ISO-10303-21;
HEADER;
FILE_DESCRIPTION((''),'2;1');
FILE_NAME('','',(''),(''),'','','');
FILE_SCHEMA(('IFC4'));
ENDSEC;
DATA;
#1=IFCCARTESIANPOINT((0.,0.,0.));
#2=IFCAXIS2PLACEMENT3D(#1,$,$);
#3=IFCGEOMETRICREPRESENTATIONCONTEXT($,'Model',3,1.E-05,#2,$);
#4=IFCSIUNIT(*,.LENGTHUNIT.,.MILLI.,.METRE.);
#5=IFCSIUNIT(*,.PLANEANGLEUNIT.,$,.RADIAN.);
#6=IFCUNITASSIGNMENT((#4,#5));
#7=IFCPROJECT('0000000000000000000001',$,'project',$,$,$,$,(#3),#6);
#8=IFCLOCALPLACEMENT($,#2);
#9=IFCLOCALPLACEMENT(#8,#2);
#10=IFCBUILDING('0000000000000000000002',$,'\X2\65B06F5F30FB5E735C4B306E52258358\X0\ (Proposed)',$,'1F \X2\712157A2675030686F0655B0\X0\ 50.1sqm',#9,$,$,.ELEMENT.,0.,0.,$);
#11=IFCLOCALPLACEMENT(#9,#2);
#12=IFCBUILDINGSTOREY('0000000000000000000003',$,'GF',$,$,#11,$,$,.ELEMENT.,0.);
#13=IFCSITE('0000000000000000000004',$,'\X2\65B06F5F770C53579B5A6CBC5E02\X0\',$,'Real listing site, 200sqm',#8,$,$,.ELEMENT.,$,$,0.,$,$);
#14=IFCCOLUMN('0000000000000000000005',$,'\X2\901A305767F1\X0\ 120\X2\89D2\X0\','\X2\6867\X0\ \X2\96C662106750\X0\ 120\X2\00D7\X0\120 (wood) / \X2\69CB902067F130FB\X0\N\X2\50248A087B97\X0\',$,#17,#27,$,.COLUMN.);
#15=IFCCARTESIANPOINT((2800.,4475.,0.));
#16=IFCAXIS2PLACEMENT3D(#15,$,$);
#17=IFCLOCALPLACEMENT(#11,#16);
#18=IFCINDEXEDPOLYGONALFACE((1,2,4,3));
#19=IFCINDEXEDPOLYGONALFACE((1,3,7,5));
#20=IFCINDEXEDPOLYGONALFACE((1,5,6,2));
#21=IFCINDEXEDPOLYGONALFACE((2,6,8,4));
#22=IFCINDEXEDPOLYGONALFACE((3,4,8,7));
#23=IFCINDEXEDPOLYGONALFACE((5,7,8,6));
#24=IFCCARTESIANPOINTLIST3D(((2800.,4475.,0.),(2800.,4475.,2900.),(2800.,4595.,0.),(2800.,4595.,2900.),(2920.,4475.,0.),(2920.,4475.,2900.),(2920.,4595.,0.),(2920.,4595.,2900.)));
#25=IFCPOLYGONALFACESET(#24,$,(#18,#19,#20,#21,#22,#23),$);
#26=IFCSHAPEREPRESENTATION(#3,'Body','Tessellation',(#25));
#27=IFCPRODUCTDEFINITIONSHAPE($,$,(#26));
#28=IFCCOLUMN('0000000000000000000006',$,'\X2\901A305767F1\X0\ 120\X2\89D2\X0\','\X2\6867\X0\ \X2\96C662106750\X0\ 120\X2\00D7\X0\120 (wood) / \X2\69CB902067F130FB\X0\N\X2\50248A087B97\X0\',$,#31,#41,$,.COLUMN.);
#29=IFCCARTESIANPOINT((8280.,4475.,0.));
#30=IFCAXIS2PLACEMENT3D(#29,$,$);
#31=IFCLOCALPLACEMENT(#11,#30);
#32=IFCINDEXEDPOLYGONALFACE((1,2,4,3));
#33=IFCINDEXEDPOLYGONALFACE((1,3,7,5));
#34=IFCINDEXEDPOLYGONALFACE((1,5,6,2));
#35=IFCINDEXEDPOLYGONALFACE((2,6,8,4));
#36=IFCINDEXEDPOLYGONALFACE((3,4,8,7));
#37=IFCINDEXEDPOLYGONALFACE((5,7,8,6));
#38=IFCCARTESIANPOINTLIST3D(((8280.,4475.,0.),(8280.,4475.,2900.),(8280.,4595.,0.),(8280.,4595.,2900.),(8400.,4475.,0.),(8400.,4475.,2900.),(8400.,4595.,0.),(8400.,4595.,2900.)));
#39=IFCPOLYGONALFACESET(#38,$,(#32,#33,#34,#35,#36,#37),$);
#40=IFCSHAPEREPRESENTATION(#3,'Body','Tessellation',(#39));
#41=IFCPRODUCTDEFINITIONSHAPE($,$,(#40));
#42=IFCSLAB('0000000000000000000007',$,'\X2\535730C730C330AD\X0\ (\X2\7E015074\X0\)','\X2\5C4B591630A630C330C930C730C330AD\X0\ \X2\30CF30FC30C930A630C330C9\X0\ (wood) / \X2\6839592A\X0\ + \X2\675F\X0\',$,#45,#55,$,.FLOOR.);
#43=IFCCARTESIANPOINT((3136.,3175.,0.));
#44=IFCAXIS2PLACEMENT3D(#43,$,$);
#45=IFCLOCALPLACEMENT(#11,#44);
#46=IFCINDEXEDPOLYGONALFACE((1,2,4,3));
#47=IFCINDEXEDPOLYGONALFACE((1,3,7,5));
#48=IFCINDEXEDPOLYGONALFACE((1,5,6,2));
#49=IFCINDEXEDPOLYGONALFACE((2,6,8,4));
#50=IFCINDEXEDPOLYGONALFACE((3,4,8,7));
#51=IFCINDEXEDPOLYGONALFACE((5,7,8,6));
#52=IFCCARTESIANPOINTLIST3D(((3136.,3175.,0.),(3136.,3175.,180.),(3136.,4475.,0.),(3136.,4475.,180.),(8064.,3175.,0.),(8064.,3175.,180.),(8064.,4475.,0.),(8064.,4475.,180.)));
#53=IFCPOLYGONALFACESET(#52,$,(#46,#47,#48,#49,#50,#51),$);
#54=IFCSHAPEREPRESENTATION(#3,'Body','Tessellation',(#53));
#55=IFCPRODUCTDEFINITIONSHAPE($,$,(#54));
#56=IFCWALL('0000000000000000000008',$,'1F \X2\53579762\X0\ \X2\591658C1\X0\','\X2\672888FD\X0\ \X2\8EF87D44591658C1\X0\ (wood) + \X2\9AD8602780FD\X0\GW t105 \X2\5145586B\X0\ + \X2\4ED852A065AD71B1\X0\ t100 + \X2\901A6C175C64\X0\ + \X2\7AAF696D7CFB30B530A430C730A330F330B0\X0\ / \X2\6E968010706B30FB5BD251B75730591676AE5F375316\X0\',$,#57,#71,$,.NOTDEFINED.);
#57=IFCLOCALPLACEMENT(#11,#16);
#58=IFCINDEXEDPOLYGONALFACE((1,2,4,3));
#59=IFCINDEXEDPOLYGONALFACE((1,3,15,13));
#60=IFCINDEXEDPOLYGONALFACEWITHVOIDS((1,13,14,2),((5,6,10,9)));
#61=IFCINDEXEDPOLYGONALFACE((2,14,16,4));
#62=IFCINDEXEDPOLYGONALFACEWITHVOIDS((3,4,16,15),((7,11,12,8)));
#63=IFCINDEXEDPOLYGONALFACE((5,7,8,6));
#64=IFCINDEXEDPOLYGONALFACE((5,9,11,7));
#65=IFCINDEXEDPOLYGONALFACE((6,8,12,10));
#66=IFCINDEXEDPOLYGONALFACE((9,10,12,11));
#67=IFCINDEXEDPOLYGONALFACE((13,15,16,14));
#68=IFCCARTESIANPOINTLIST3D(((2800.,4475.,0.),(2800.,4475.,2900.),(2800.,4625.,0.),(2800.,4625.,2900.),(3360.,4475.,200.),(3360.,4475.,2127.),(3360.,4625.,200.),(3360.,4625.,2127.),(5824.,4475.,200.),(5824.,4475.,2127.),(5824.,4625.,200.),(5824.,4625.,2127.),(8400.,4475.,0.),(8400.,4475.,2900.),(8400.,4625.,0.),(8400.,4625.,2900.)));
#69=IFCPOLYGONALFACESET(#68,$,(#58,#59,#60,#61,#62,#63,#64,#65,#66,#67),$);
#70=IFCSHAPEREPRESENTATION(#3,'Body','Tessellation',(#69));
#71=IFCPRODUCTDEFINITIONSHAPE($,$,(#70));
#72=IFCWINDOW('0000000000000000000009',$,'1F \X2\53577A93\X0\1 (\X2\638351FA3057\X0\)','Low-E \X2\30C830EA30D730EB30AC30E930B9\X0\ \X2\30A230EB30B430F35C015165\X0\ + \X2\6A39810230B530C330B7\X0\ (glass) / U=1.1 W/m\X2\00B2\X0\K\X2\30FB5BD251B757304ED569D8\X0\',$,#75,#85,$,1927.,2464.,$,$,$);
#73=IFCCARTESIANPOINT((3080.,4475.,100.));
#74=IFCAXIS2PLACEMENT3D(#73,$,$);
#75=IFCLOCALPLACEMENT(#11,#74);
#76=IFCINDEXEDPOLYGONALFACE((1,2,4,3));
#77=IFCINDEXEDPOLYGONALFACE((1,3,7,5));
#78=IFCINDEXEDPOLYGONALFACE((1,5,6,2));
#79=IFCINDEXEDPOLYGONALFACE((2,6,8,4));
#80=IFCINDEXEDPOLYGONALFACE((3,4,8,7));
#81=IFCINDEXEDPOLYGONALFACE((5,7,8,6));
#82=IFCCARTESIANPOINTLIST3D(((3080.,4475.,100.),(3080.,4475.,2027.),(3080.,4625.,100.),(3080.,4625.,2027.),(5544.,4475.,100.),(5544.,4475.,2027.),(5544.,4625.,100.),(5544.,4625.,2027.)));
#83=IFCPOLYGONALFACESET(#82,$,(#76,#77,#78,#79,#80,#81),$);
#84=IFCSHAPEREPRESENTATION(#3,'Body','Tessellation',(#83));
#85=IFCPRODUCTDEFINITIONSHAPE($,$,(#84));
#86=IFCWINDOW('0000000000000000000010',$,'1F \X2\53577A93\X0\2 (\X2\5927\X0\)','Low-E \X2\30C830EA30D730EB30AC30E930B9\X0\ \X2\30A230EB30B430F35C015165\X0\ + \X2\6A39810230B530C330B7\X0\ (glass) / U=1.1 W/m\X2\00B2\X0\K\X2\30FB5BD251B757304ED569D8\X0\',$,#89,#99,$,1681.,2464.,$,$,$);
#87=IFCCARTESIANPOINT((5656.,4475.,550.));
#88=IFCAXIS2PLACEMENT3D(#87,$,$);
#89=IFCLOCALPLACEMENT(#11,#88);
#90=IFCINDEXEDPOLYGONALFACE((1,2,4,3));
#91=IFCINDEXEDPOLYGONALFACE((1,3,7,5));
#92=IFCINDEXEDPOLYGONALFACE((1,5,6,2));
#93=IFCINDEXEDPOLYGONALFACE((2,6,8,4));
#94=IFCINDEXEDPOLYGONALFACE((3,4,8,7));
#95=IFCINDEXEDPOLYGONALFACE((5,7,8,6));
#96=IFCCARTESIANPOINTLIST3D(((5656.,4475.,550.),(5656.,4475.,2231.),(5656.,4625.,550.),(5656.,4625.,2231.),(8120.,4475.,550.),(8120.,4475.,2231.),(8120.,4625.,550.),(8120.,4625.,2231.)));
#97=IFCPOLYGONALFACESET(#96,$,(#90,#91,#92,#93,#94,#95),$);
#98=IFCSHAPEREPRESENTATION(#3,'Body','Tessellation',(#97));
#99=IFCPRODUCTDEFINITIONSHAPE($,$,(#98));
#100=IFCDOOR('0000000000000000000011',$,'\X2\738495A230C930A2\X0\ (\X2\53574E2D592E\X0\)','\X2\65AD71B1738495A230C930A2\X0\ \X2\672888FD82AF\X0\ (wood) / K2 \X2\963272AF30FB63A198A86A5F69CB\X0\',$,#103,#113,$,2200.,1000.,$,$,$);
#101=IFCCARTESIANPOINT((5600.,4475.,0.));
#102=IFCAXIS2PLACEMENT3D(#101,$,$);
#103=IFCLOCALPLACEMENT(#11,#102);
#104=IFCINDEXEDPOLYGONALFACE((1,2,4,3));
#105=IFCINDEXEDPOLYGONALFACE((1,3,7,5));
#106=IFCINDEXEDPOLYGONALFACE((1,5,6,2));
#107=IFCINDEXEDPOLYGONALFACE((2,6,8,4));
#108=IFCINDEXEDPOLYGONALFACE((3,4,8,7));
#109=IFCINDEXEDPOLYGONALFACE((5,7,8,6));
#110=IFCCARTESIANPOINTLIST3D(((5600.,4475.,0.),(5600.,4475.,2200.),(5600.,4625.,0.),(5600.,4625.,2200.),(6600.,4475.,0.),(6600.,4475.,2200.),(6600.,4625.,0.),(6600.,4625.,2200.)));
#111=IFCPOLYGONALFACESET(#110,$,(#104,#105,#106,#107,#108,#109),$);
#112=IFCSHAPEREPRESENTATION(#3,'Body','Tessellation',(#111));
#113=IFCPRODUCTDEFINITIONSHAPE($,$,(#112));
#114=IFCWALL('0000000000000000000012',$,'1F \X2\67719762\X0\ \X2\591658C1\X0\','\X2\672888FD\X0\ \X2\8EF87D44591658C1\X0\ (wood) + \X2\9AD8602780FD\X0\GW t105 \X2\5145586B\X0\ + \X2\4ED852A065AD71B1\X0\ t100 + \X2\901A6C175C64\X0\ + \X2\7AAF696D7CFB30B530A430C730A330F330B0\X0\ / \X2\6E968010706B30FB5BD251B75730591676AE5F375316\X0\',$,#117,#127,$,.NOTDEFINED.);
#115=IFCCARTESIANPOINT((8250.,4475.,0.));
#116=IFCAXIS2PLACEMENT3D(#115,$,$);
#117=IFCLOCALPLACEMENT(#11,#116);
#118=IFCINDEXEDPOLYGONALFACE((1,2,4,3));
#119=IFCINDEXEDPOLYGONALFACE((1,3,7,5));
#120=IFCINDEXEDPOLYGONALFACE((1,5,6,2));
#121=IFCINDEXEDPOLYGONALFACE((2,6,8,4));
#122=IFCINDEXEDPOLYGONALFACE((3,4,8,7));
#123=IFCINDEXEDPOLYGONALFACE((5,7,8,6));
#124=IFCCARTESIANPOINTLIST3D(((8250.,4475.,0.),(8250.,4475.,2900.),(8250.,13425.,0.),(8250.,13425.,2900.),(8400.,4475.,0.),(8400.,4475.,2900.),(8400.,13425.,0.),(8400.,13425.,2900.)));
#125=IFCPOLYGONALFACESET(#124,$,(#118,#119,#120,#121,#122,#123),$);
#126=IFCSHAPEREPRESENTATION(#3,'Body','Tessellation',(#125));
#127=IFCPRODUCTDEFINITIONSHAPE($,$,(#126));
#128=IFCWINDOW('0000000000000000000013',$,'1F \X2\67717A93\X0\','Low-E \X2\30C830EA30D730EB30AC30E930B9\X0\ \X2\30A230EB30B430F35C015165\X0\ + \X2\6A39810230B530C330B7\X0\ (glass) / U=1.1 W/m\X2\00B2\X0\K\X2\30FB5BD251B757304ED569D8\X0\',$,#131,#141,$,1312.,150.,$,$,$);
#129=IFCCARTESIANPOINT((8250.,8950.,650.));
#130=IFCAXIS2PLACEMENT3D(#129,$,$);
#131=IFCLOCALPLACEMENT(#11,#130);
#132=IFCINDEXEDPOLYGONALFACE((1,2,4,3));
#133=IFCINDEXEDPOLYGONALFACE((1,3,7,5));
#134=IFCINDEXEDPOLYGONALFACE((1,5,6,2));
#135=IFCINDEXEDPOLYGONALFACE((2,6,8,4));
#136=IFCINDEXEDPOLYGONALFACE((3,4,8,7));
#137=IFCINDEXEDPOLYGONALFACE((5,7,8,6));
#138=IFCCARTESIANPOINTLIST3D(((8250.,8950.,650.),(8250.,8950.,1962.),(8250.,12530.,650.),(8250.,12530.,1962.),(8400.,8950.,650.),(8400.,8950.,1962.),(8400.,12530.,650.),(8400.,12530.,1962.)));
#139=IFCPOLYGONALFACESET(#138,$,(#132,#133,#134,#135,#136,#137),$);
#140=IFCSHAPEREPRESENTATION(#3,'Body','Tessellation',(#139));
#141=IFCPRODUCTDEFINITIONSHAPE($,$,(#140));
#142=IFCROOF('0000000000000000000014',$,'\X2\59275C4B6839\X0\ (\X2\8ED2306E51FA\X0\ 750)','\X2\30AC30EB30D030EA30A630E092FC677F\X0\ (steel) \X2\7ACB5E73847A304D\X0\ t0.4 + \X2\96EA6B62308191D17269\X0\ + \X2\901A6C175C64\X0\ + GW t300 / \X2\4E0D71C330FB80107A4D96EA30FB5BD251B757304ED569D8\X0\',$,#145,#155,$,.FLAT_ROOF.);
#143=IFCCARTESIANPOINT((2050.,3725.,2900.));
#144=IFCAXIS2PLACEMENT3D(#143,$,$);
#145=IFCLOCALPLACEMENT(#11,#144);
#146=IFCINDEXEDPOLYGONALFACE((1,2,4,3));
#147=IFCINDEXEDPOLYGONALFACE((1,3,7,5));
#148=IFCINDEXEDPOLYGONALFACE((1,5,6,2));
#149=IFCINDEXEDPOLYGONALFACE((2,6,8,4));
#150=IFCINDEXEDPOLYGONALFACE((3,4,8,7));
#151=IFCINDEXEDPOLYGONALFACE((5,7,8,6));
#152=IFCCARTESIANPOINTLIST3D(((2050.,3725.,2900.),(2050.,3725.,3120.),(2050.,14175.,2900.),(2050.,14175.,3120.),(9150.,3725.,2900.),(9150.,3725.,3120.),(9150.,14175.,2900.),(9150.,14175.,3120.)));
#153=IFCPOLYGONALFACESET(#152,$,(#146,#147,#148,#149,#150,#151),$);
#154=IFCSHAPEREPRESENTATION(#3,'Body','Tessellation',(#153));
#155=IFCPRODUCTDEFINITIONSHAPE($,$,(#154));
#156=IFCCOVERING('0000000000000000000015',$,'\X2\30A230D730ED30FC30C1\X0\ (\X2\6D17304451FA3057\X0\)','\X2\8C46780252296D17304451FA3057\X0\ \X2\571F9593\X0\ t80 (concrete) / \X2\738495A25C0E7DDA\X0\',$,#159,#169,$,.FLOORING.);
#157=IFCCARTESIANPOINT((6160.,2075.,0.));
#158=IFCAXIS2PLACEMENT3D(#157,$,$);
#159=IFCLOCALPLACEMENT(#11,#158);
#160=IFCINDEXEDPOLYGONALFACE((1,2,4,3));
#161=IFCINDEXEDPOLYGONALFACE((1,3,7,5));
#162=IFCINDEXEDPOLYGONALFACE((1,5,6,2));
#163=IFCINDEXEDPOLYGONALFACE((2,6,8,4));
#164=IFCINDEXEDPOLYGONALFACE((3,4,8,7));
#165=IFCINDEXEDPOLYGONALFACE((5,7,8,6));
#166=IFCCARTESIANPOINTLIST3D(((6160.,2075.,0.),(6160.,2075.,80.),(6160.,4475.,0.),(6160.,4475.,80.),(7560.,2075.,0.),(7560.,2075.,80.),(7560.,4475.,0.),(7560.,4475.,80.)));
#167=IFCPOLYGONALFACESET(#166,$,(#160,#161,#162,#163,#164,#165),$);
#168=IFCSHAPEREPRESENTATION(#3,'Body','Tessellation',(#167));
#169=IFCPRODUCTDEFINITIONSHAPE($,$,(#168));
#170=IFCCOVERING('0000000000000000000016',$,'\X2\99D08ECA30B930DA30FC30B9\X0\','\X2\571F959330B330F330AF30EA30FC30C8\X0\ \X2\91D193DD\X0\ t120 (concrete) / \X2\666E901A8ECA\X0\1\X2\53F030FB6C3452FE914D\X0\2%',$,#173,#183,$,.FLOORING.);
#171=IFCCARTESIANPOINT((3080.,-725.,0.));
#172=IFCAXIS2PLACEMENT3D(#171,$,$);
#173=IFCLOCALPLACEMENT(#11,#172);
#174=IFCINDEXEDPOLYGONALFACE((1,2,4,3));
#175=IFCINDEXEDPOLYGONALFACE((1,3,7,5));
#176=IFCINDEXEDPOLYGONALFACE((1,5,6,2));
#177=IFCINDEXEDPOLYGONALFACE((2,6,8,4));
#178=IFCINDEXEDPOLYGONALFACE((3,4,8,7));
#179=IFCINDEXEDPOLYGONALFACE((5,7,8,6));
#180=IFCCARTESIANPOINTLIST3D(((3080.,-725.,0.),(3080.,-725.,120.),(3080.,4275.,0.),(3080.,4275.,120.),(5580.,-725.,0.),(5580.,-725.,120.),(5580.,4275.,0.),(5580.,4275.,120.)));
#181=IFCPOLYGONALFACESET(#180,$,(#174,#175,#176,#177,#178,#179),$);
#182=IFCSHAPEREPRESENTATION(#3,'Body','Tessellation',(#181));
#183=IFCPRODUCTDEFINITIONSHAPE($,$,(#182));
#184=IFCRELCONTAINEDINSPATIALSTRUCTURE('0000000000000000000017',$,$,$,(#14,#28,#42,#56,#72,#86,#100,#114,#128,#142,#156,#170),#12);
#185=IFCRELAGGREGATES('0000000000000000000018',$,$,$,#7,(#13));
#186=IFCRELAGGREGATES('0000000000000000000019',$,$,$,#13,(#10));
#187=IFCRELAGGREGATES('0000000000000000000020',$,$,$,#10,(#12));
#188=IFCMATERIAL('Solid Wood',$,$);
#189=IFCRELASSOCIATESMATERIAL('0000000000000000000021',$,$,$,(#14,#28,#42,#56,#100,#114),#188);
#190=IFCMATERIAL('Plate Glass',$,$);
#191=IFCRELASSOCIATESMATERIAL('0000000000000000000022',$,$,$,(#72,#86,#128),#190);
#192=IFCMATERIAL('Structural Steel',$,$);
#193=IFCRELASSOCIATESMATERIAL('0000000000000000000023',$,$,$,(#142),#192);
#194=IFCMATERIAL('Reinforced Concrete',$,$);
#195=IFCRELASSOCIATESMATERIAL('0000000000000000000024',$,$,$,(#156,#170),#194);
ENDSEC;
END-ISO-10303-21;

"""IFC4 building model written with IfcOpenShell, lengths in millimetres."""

from ifc_helpers import new_model, si_unit, frame, frame_2d, origin, place, context, project, spatial, rectangle, extrude, material, element, fill, save


model = new_model("IFC4")

# Units and contexts
model_context = context("Model", 3, precision=1e-05, world=origin())
ifc_project = project(units=[si_unit("LENGTHUNIT", "METRE", prefix="MILLI"), si_unit("PLANEANGLEUNIT", "RADIAN")], contexts=[model_context])

# Site, building, storey
site_placement = place(None, origin())
site = spatial("IfcSite", under=ifc_project, at=site_placement, Name="新潟県南魚沼市", ObjectType="Real listing site, 200sqm", CompositionType="ELEMENT", RefElevation=0.0)
building_placement = place(site_placement, origin())
building = spatial("IfcBuilding", under=site, at=building_placement, Name="新潟・平屋の別荘 (Proposed)", ObjectType="1F 無垢材と漆喰 50.1sqm", CompositionType="ELEMENT", ElevationOfRefHeight=0.0, ElevationOfTerrain=0.0)
storey_placement = place(building_placement, origin())
storey = spatial("IfcBuildingStorey", under=building, at=storey_placement, Name="GF", CompositionType="ELEMENT", Elevation=0.0)

# Columns
ifc_material_1 = material(Name="Solid Wood")
column_1_placement = place(storey_placement, frame((2800.0, 4475.0, 0.0)))
element("IfcColumn", 1, at=column_1_placement, inside=storey, material=ifc_material_1, Name="通し柱 120角", Description="桧 集成材 120×120 (wood) / 構造柱・N値計算", PredefinedType="COLUMN", context=model_context, shape_type="SweptSolid", body=[
    extrude(rectangle(XDim=120.0, YDim=120.0, at=frame_2d((60.0, 60.0))), frame((2800.0, 4475.0, 0.0)), (0.0, 0.0, 1.0), 2900.0),
])
column_2_placement = place(storey_placement, frame((8280.0, 4475.0, 0.0)))
element("IfcColumn", 2, at=column_2_placement, inside=storey, material=ifc_material_1, Name="通し柱 120角", Description="桧 集成材 120×120 (wood) / 構造柱・N値計算", PredefinedType="COLUMN", context=model_context, shape_type="SweptSolid", body=[
    extrude(rectangle(XDim=120.0, YDim=120.0, at=frame_2d((60.0, 60.0))), frame((8280.0, 4475.0, 0.0)), (0.0, 0.0, 1.0), 2900.0),
])

# Slab
ifc_material_2 = material(Name="Reinforced Concrete")
slab_1_placement = place(storey_placement, frame((3136.0, 3175.0, 0.0)))
element("IfcSlab", 3, at=slab_1_placement, inside=storey, material=ifc_material_1, Name="南デッキ (縁側)", Description="屋外ウッドデッキ ハードウッド (wood) / 根太 + 束", PredefinedType="FLOOR", context=model_context, shape_type="SweptSolid", body=[
    extrude(rectangle(XDim=4928.0, YDim=1300.0, at=frame_2d((2464.0, 650.0))), frame((3136.0, 3175.0, 0.0)), (0.0, 0.0, 1.0), 180.0),
])

# Wall, openings, windows, door
wall_1_placement = place(storey_placement, frame((2800.0, 4475.0, 0.0)))
wall_1 = element("IfcWall", 4, at=wall_1_placement, inside=storey, material=ifc_material_1, Name="1F 南面 外壁", Description="木製 軸組外壁 (wood) + 高性能GW t105 充填 + 付加断熱 t100 + 通気層 + 窯業系サイディング / 準耐火・寒冷地外皮強化", PredefinedType="NOTDEFINED", context=model_context, shape_type="SweptSolid", body=[
    extrude(rectangle(XDim=5600.0, YDim=150.0, at=frame_2d((2800.0, 75.0))), frame((2800.0, 4475.0, 0.0)), (0.0, 0.0, 1.0), 2900.0),
])
opening_1_placement = place(storey_placement, frame((3080.0, 4475.0, 100.0)))
opening_1 = element("IfcOpeningElement", 5, at=opening_1_placement, cuts=wall_1, PredefinedType="NOTDEFINED", context=model_context, shape_type="SweptSolid", body=[
    extrude(rectangle(XDim=2464.0, YDim=150.0, at=frame_2d((1232.0, 75.0))), frame((3080.0, 4475.0, 100.0)), (0.0, 0.0, 1.0), 1927.0),
])
opening_2_placement = place(storey_placement, frame((5656.0, 4475.0, 550.0)))
opening_2 = element("IfcOpeningElement", 6, at=opening_2_placement, cuts=wall_1, PredefinedType="NOTDEFINED", context=model_context, shape_type="SweptSolid", body=[
    extrude(rectangle(XDim=2464.0, YDim=150.0, at=frame_2d((1232.0, 75.0))), frame((5656.0, 4475.0, 550.0)), (0.0, 0.0, 1.0), 1681.0),
])
opening_3_placement = place(storey_placement, frame((5600.0, 4475.0, 0.0)))
opening_3 = element("IfcOpeningElement", 7, at=opening_3_placement, cuts=wall_1, PredefinedType="NOTDEFINED", context=model_context, shape_type="SweptSolid", body=[
    extrude(rectangle(XDim=1000.0, YDim=150.0, at=frame_2d((500.0, 75.0))), frame((5600.0, 4475.0, 0.0)), (0.0, 0.0, 1.0), 2200.0),
])
ifc_material_3 = material(Name="Plate Glass")
window_1_placement = place(storey_placement, frame((3080.0, 4475.0, 100.0)))
window_1 = element("IfcWindow", 8, at=window_1_placement, inside=storey, material=ifc_material_3, Name="1F 南窓1 (掃出し)", Description="Low-E トリプルガラス アルゴン封入 + 樹脂サッシ (glass) / U=1.1 W/m²K・寒冷地仕様", OverallHeight=1927.0, OverallWidth=2464.0, context=model_context, shape_type="SweptSolid", body=[
    extrude(rectangle(XDim=2464.0, YDim=150.0, at=frame_2d((1232.0, 75.0))), frame((3080.0, 4475.0, 100.0)), (0.0, 0.0, 1.0), 1927.0),
])
fill(opening_1, window_1)
window_2_placement = place(storey_placement, frame((5656.0, 4475.0, 550.0)))
window_2 = element("IfcWindow", 9, at=window_2_placement, inside=storey, material=ifc_material_3, Name="1F 南窓2 (大)", Description="Low-E トリプルガラス アルゴン封入 + 樹脂サッシ (glass) / U=1.1 W/m²K・寒冷地仕様", OverallHeight=1681.0, OverallWidth=2464.0, context=model_context, shape_type="SweptSolid", body=[
    extrude(rectangle(XDim=2464.0, YDim=150.0, at=frame_2d((1232.0, 75.0))), frame((5656.0, 4475.0, 550.0)), (0.0, 0.0, 1.0), 1681.0),
])
fill(opening_2, window_2)
door_placement = place(storey_placement, frame((5600.0, 4475.0, 0.0)))
door = element("IfcDoor", 10, at=door_placement, inside=storey, material=ifc_material_1, Name="玄関ドア (南中央)", Description="断熱玄関ドア 木製芯 (wood) / K2 防犯・採風機構", OverallHeight=2200.0, OverallWidth=1000.0, context=model_context, shape_type="SweptSolid", body=[
    extrude(rectangle(XDim=1000.0, YDim=150.0, at=frame_2d((500.0, 75.0))), frame((5600.0, 4475.0, 0.0)), (0.0, 0.0, 1.0), 2200.0),
])
fill(opening_3, door)

# Wall, opening, window
wall_2_placement = place(storey_placement, frame((8250.0, 4475.0, 0.0)))
wall_2 = element("IfcWall", 11, at=wall_2_placement, inside=storey, material=ifc_material_1, Name="1F 東面 外壁", Description="木製 軸組外壁 (wood) + 高性能GW t105 充填 + 付加断熱 t100 + 通気層 + 窯業系サイディング / 準耐火・寒冷地外皮強化", PredefinedType="NOTDEFINED", context=model_context, shape_type="SweptSolid", body=[
    extrude(rectangle(XDim=150.0, YDim=8950.0, at=frame_2d((75.0, 4475.0))), frame((8250.0, 4475.0, 0.0)), (0.0, 0.0, 1.0), 2900.0),
])
opening_4_placement = place(storey_placement, frame((8250.0, 8950.0, 650.0)))
opening_4 = element("IfcOpeningElement", 12, at=opening_4_placement, cuts=wall_2, PredefinedType="NOTDEFINED", context=model_context, shape_type="SweptSolid", body=[
    extrude(rectangle(XDim=150.0, YDim=3580.0, at=frame_2d((75.0, 1790.0))), frame((8250.0, 8950.0, 650.0)), (0.0, 0.0, 1.0), 1312.0),
])
window_3_placement = place(storey_placement, frame((8250.0, 8950.0, 650.0)))
window_3 = element("IfcWindow", 13, at=window_3_placement, inside=storey, material=ifc_material_3, Name="1F 東窓", Description="Low-E トリプルガラス アルゴン封入 + 樹脂サッシ (glass) / U=1.1 W/m²K・寒冷地仕様", OverallHeight=1312.0, OverallWidth=150.0, context=model_context, shape_type="SweptSolid", body=[
    extrude(rectangle(XDim=150.0, YDim=3580.0, at=frame_2d((75.0, 1790.0))), frame((8250.0, 8950.0, 650.0)), (0.0, 0.0, 1.0), 1312.0),
])
fill(opening_4, window_3)

# Roof
ifc_material_4 = material(Name="Structural Steel")
roof_placement = place(storey_placement, frame((2050.0, 3725.0, 2900.0)))
element("IfcRoof", 14, at=roof_placement, inside=storey, material=ifc_material_4, Name="大屋根 (軒の出 750)", Description="ガルバリウム鋼板 (steel) 立平葺き t0.4 + 雪止め金物 + 通気層 + GW t300 / 不燃・耐積雪・寒冷地仕様", PredefinedType="FLAT_ROOF", context=model_context, shape_type="SweptSolid", body=[
    extrude(rectangle(XDim=7100.0, YDim=10450.0, at=frame_2d((3550.0, 5225.0))), frame((2050.0, 3725.0, 2900.0)), (0.0, 0.0, 1.0), 220.0),
])

# Coverings
covering_1_placement = place(storey_placement, frame((6160.0, 2075.0, 0.0)))
element("IfcCovering", 15, at=covering_1_placement, inside=storey, material=ifc_material_2, Name="アプローチ (洗い出し)", Description="豆砂利洗い出し 土間 t80 (concrete) / 玄関導線", PredefinedType="FLOORING", context=model_context, shape_type="SweptSolid", body=[
    extrude(rectangle(XDim=1400.0, YDim=2400.0, at=frame_2d((700.0, 1200.0))), frame((6160.0, 2075.0, 0.0)), (0.0, 0.0, 1.0), 80.0),
])
covering_2_placement = place(storey_placement, frame((3080.0, -725.0, 0.0)))
element("IfcCovering", 16, at=covering_2_placement, inside=storey, material=ifc_material_2, Name="駐車スペース", Description="土間コンクリート 金鏝 t120 (concrete) / 普通車1台・水勾配2%", PredefinedType="FLOORING", context=model_context, shape_type="SweptSolid", body=[
    extrude(rectangle(XDim=2500.0, YDim=5000.0, at=frame_2d((1250.0, 2500.0))), frame((3080.0, -725.0, 0.0)), (0.0, 0.0, 1.0), 120.0),
])

save(model, "model.ifc")
